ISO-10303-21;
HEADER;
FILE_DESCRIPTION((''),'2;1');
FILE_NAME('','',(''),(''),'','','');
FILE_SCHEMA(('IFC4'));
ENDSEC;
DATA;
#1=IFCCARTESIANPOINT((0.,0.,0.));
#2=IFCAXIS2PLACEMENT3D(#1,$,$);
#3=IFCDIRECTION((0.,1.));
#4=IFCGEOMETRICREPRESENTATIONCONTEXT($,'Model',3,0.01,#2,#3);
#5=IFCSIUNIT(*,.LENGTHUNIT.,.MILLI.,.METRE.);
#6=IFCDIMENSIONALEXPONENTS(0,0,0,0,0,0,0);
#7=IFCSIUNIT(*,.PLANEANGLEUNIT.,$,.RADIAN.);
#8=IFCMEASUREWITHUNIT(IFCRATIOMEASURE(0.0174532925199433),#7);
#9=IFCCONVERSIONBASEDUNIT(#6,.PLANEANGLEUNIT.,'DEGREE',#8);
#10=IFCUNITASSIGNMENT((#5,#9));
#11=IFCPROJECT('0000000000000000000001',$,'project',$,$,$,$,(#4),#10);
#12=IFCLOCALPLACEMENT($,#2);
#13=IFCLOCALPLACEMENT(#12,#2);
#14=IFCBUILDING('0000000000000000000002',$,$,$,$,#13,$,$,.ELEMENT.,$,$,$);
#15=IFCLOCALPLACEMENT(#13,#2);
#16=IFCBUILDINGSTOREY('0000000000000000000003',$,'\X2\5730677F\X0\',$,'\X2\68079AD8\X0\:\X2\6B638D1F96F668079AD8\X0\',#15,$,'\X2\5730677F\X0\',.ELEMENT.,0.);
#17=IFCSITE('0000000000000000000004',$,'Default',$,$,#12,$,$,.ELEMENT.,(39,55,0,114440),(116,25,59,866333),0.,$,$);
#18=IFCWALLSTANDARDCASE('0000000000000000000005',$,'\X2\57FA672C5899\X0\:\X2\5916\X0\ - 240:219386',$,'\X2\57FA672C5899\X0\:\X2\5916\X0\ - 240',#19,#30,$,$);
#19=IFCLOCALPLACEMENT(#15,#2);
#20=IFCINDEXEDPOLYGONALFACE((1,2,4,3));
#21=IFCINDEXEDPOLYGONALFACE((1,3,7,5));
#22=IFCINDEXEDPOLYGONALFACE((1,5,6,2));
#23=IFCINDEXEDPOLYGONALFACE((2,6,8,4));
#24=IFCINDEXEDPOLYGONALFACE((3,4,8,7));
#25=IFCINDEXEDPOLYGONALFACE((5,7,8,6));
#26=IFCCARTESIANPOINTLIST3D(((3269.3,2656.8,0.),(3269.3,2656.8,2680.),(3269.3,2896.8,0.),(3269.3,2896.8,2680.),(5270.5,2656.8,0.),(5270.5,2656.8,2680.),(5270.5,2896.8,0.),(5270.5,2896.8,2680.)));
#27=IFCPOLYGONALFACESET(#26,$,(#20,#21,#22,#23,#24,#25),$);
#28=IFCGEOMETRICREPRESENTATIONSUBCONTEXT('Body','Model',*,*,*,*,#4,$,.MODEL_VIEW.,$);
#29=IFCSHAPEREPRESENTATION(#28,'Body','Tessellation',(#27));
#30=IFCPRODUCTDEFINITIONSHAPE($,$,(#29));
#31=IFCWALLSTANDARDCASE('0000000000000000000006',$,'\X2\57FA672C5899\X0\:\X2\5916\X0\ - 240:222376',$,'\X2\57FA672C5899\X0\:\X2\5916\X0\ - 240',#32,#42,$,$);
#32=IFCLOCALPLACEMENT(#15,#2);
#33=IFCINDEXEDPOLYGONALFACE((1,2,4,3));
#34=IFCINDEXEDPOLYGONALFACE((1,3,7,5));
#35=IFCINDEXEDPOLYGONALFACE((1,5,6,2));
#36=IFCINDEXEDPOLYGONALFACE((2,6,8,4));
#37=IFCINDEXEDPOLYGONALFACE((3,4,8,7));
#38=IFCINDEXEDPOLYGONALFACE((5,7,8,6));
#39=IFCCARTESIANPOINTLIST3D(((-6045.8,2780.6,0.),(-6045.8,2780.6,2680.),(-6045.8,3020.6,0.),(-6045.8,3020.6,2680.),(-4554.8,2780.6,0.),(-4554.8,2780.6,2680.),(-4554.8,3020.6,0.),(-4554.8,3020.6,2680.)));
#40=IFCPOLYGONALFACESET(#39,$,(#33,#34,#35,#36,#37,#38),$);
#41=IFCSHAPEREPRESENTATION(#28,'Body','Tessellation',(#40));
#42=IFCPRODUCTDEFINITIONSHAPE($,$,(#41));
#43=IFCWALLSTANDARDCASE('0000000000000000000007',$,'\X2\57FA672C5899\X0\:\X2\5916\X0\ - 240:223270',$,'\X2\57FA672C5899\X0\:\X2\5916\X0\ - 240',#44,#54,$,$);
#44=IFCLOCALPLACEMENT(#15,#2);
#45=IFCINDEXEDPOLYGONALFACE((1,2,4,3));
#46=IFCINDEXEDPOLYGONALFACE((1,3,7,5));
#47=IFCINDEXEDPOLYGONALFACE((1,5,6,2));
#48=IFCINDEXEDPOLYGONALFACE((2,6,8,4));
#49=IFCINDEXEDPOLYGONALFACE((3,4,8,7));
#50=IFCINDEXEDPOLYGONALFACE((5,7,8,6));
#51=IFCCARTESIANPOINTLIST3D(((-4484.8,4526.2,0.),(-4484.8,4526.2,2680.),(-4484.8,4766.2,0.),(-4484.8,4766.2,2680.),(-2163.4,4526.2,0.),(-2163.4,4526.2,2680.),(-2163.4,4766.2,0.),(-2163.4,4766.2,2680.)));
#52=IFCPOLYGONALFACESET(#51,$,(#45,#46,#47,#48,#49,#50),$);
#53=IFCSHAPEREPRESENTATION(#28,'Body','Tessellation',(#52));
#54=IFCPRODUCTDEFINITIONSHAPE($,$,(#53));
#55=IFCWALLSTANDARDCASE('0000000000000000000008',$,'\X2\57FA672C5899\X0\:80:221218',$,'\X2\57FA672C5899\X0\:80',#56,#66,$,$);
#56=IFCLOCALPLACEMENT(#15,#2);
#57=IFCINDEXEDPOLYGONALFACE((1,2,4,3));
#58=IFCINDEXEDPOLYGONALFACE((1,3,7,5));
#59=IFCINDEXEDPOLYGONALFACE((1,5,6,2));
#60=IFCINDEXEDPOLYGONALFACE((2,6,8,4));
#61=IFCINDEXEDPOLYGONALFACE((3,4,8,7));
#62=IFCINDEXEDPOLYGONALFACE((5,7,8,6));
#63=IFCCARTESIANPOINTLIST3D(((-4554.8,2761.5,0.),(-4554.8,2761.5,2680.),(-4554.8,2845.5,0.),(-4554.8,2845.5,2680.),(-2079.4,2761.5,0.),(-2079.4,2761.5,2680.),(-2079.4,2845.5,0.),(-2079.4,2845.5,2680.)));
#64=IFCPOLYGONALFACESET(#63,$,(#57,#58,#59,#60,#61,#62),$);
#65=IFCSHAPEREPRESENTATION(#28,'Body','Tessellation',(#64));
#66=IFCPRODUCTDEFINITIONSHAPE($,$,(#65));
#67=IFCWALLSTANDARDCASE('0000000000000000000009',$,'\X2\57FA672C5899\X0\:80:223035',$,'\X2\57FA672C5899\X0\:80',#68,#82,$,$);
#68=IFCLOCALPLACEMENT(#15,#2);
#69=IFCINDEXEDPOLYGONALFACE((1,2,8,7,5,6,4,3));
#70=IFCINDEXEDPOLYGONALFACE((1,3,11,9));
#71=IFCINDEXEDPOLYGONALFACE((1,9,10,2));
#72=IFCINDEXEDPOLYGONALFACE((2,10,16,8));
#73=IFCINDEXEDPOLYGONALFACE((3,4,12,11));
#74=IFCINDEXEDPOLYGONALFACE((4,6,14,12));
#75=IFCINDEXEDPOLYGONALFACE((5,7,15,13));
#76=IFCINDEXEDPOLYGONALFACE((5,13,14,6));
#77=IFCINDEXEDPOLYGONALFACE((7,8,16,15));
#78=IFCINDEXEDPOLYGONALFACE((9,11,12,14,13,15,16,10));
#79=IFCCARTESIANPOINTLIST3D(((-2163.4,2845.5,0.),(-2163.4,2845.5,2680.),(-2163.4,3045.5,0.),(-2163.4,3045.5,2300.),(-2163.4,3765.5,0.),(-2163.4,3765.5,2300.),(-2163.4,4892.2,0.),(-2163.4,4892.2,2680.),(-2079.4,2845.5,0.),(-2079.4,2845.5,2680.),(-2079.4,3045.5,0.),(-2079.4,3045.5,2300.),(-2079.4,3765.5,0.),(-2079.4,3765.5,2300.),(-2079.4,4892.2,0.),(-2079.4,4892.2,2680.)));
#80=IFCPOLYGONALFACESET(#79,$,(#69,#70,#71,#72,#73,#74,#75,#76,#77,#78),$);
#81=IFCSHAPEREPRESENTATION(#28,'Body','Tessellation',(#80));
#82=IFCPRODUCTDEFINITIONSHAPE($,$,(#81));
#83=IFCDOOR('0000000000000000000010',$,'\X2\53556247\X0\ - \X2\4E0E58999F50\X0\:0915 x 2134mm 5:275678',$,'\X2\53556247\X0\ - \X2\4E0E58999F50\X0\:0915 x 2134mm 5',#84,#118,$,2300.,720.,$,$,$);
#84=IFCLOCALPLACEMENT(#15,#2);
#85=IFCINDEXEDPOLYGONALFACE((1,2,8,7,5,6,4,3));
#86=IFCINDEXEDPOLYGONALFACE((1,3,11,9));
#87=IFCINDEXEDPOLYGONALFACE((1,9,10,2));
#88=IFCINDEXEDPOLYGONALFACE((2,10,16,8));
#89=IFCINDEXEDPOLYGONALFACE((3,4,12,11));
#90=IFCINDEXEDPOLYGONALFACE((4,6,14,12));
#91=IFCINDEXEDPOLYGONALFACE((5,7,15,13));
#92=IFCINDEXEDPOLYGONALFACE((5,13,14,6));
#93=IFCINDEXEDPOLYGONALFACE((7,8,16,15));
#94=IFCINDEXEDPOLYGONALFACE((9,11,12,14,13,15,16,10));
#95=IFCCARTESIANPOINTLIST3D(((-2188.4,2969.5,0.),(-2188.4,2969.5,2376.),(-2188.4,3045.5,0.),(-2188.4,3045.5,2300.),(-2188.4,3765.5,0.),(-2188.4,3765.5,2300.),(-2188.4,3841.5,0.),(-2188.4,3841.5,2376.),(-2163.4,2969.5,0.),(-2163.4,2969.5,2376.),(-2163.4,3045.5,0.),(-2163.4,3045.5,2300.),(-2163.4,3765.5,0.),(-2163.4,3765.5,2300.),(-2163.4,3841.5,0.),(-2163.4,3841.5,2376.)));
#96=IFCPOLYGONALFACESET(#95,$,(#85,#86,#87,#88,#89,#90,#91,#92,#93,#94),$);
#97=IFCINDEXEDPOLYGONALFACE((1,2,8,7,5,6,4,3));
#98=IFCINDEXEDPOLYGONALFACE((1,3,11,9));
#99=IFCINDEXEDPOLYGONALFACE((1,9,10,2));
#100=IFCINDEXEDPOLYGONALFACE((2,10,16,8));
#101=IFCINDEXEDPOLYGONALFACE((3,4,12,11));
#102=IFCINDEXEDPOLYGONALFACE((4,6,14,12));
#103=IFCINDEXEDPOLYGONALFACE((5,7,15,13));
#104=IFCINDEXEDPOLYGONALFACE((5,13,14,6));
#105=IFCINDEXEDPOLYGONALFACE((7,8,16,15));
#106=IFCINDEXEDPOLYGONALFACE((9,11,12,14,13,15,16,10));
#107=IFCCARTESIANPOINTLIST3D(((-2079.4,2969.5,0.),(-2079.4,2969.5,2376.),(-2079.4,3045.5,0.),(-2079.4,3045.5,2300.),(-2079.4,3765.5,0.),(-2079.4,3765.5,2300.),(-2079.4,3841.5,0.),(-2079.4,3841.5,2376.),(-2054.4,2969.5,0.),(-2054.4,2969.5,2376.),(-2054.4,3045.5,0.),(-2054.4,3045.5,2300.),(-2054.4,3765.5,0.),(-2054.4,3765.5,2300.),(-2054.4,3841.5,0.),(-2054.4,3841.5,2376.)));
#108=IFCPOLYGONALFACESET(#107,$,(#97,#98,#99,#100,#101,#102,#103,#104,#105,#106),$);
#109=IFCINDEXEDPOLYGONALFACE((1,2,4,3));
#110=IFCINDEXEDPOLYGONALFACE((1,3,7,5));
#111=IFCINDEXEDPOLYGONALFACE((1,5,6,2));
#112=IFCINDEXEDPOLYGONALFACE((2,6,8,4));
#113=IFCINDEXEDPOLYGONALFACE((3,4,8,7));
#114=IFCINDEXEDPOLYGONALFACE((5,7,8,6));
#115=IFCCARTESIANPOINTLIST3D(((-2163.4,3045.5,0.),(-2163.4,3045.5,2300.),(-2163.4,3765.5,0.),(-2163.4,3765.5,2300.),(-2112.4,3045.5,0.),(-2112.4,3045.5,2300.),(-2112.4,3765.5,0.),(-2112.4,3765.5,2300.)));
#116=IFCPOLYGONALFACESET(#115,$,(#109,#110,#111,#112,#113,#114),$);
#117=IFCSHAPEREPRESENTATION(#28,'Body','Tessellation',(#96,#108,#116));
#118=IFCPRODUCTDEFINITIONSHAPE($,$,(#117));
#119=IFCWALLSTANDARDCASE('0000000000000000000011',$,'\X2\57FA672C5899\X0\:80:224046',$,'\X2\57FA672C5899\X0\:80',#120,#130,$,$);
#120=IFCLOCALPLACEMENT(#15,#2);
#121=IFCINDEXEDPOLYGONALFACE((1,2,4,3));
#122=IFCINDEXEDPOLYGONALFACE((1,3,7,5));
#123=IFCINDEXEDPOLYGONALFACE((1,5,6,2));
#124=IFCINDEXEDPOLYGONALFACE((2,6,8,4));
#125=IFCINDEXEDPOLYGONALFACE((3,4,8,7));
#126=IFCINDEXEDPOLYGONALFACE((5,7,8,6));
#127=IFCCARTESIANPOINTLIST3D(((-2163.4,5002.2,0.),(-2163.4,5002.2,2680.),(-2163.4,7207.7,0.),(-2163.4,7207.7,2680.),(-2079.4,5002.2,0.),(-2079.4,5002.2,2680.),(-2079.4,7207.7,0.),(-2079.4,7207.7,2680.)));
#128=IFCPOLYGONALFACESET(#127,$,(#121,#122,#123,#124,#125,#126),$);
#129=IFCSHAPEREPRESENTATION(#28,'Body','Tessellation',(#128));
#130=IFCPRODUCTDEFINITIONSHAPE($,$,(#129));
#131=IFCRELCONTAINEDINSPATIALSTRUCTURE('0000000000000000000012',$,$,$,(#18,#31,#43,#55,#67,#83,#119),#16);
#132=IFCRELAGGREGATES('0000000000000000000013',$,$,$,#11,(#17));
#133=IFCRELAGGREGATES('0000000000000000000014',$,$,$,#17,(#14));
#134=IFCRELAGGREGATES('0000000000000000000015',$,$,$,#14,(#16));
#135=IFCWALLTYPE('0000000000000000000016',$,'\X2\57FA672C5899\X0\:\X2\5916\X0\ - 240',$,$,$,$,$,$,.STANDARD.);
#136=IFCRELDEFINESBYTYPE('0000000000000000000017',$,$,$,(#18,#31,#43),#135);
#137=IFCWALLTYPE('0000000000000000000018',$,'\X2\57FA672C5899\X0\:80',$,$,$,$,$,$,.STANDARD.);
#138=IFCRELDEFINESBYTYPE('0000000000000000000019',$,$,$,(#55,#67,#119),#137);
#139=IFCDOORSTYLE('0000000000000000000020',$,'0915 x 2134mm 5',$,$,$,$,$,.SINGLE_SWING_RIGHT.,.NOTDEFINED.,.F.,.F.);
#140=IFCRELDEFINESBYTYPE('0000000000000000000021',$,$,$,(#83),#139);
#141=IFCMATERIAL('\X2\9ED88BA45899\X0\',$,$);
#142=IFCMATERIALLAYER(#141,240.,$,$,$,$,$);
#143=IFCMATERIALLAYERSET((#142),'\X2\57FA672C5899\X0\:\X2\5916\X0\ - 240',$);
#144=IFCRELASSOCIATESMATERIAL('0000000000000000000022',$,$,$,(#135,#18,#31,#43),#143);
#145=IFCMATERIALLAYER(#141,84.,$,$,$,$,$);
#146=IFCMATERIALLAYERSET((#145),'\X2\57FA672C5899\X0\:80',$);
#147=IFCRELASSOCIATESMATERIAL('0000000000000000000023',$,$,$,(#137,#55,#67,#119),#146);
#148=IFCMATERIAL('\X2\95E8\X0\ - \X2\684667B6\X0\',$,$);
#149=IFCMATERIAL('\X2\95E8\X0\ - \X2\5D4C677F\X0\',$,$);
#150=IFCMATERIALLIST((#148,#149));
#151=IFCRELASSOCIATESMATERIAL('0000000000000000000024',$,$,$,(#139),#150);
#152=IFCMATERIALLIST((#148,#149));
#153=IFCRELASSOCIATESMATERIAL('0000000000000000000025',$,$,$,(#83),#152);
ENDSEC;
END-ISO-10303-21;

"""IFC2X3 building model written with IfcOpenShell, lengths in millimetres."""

from ifc_helpers import new_model, entity, si_unit, converted_unit, direction, frame, frame_2d, origin, origin_2d_with_axis, place, context, subcontext, project, spatial, polyline, rectangle, outline, extrude, source, transform, mapped, material, material_list, layer, layer_set, layer_usage, type_object, type_shapes, element, fill, save


model = new_model("IFC2X3")

# Units and contexts
model_context = context("Model", 3, precision=0.01, world=origin(), true_north=direction((0.0, 1.0)))
body_context = subcontext(model_context, "Body", "Model", "MODEL_VIEW")
ifc_project = project(units=[si_unit("LENGTHUNIT", "METRE", prefix="MILLI"), converted_unit("PLANEANGLEUNIT", "DEGREE", entity("IfcRatioMeasure", 0.0174532925199433), si_unit("PLANEANGLEUNIT", "RADIAN"), dimensions=[0, 0, 0, 0, 0, 0, 0])], contexts=[model_context])

# Site, building, storey
site_placement = place(None, origin())
site = spatial("IfcSite", under=ifc_project, at=site_placement, Name="Default", CompositionType="ELEMENT", RefLatitude=(39, 55, 0, 114440), RefLongitude=(116, 25, 59, 866333), RefElevation=0.0)
building_placement = place(site_placement, origin())
building = spatial("IfcBuilding", under=site, at=building_placement, CompositionType="ELEMENT")
storey_placement = place(building_placement, origin())
storey = spatial("IfcBuildingStorey", under=building, at=storey_placement, Name="地板", ObjectType="标高:正负零标高", LongName="地板", CompositionType="ELEMENT", Elevation=0.0)

# Shared definitions
ifc_material_1 = material(Name="默认墙")

# Walls
ifc_layer_1 = layer(ifc_material_1, 240.0)
ifc_layer_set_1 = layer_set([ifc_layer_1], Name="基本墙:外 - 240")
ifc_layer_usage_1 = layer_usage(ifc_layer_set_1, "AXIS2", "POSITIVE", -120.0)
wall_type_1 = type_object("IfcWallType", Name="基本墙:外 - 240", PredefinedType="STANDARD", material=ifc_layer_set_1)
wall_1_placement = place(storey_placement, frame((3269.3, 2776.8, 0.0)))
element("IfcWallStandardCase", 1, at=wall_1_placement, inside=storey, type_object=wall_type_1, material=ifc_layer_usage_1, Name="基本墙:外 - 240:219386", ObjectType="基本墙:外 - 240", context=body_context, shape_type="SweptSolid", body=[
    extrude(rectangle(XDim=2001.2, YDim=240.0, at=frame_2d((1000.6, 0.0), x_axis=(-1.0, 0.0))), origin(), (0.0, 0.0, 1.0), 2680.0),
])
ifc_layer_usage_2 = layer_usage(ifc_layer_set_1, "AXIS2", "NEGATIVE", 120.0)
wall_2_placement = place(storey_placement, frame((-6045.8, 2900.6, 0.0)))
element("IfcWallStandardCase", 2, at=wall_2_placement, inside=storey, type_object=wall_type_1, material=ifc_layer_usage_2, Name="基本墙:外 - 240:222376", ObjectType="基本墙:外 - 240", context=body_context, shape_type="SweptSolid", body=[
    extrude(rectangle(XDim=1491.1, YDim=240.0, at=frame_2d((745.5, 0.0), x_axis=(-1.0, 0.0))), origin(), (0.0, 0.0, 1.0), 2680.0),
])
ifc_layer_usage_3 = layer_usage(ifc_layer_set_1, "AXIS2", "NEGATIVE", 120.0)
wall_3_placement = place(storey_placement, frame((-4484.8, 4646.2, 0.0)))
element("IfcWallStandardCase", 3, at=wall_3_placement, inside=storey, type_object=wall_type_1, material=ifc_layer_usage_3, Name="基本墙:外 - 240:223270", ObjectType="基本墙:外 - 240", context=body_context, shape_type="SweptSolid", body=[
    extrude(rectangle(XDim=2321.3, YDim=240.0, at=frame_2d((1160.7, 0.0), x_axis=(-1.0, 0.0))), origin(), (0.0, 0.0, 1.0), 2680.0),
])
ifc_layer_2 = layer(ifc_material_1, 84.0)
ifc_layer_set_2 = layer_set([ifc_layer_2], Name="基本墙:80")
ifc_layer_usage_4 = layer_usage(ifc_layer_set_2, "AXIS2", "NEGATIVE", 42.0)
wall_type_2 = type_object("IfcWallType", Name="基本墙:80", PredefinedType="STANDARD", material=ifc_layer_set_2)
wall_4_placement = place(storey_placement, frame((-4554.8, 2803.5, 0.0)))
element("IfcWallStandardCase", 4, at=wall_4_placement, inside=storey, type_object=wall_type_2, material=ifc_layer_usage_4, Name="基本墙:80:221218", ObjectType="基本墙:80", context=body_context, shape_type="SweptSolid", body=[
    extrude(rectangle(XDim=2475.3, YDim=84.0, at=frame_2d((1237.7, 0.0), x_axis=(-1.0, 0.0))), origin(), (0.0, 0.0, 1.0), 2680.0),
])

# Wall, opening, door
ifc_layer_usage_5 = layer_usage(ifc_layer_set_2, "AXIS2", "NEGATIVE", 42.0)
wall_5_placement = place(storey_placement, frame((-2121.4, 2845.5, 0.0), z_axis=(0.0, 0.0, 1.0), x_axis=(0.0, 1.0, 0.0)))
wall_5 = element("IfcWallStandardCase", 5, at=wall_5_placement, inside=storey, type_object=wall_type_2, material=ifc_layer_usage_5, Name="基本墙:80:223035", ObjectType="基本墙:80", context=body_context, shape_type="SweptSolid", body=[
    extrude(rectangle(XDim=2046.6, YDim=84.0, at=frame_2d((1023.3, 0.0), x_axis=(-1.0, 0.0))), origin(), (0.0, 0.0, 1.0), 2680.0),
])
opening_1_placement = place(wall_5_placement, frame((200.0, -42.0, 0.0)))
opening_1 = element("IfcOpeningElement", 6, at=opening_1_placement, cuts=wall_5, ObjectType="Opening", context=body_context, shape_type="SweptSolid", body=[
    extrude(rectangle(XDim=720.0, YDim=2300.0, at=frame_2d((1150.0, 360.0), x_axis=(0.0, 1.0))), frame((0.0, 0.0, 0.0), z_axis=(0.0, 1.0, 0.0), x_axis=(0.0, 0.0, 1.0)), (0.0, 0.0, 1.0), 84.0),
])
ifc_material_2 = material(Name="门 - 框架")
ifc_material_3 = material(Name="门 - 嵌板")
ifc_material_list_1 = material_list([ifc_material_2, ifc_material_3])
ifc_material_list_2 = material_list([ifc_material_2, ifc_material_3])
door_style_1 = type_object("IfcDoorStyle", Name="0915 x 2134mm 5", ConstructionType="NOTDEFINED", OperationType="SINGLE_SWING_RIGHT", ParameterTakesPrecedence=False, Sizeable=False, material=ifc_material_list_2)
shared_shape_1 = source(origin(), body_context, "Body", "SweptSolid", [
    extrude(outline(polyline([(-436.0, -1207.0), (436.0, -1207.0), (436.0, 1169.0), (360.0, 1169.0), (360.0, -1131.0), (-360.0, -1131.0), (-360.0, 1169.0), (-436.0, 1169.0), (-436.0, -1207.0)])), frame((360.0, 84.0, 1169.0), z_axis=(0.0, 1.0, 0.0), x_axis=(1.0, 0.0, 0.0)), (0.0, 0.0, 1.0), 25.0),
    extrude(outline(polyline([(-1207.0, -436.0), (1169.0, -436.0), (1169.0, -360.0), (-1131.0, -360.0), (-1131.0, 360.0), (1169.0, 360.0), (1169.0, 436.0), (-1207.0, 436.0), (-1207.0, -436.0)])), frame((360.0, -25.0, 1169.0), z_axis=(0.0, 1.0, 0.0), x_axis=(0.0, 0.0, -1.0)), (0.0, 0.0, 1.0), 25.0),
    extrude(rectangle(XDim=51.0, YDim=720.0, at=origin_2d_with_axis()), frame((360.0, 58.5, 0.0), z_axis=(0.0, 0.0, 1.0), x_axis=(0.0, 1.0, 0.0)), (0.0, 0.0, 1.0), 2300.0),
])
type_shapes(door_style_1, [shared_shape_1])
door_1_placement = place(opening_1_placement, origin())
door_1 = element("IfcDoor", 7, at=door_1_placement, inside=storey, type_object=door_style_1, material=ifc_material_list_1, Name="单扇 - 与墙齐:0915 x 2134mm 5:275678", ObjectType="单扇 - 与墙齐:0915 x 2134mm 5", OverallHeight=2300.0, OverallWidth=720.0, context=body_context, shape_type="MappedRepresentation", body=[
    mapped(shared_shape_1, transform((0.0, 0.0, 0.0), scale=1.0)),
])
fill(opening_1, door_1)

# Wall
ifc_layer_usage_6 = layer_usage(ifc_layer_set_2, "AXIS2", "NEGATIVE", 42.0)
wall_6_placement = place(storey_placement, frame((-2121.4, 5002.2, 0.0), z_axis=(0.0, 0.0, 1.0), x_axis=(0.0, 1.0, 0.0)))
element("IfcWallStandardCase", 8, at=wall_6_placement, inside=storey, type_object=wall_type_2, material=ifc_layer_usage_6, Name="基本墙:80:224046", ObjectType="基本墙:80", context=body_context, shape_type="SweptSolid", body=[
    extrude(rectangle(XDim=2205.5, YDim=84.0, at=frame_2d((1102.8, 0.0), x_axis=(-1.0, 0.0))), origin(), (0.0, 0.0, 1.0), 2680.0),
])

save(model, "model.ifc")
